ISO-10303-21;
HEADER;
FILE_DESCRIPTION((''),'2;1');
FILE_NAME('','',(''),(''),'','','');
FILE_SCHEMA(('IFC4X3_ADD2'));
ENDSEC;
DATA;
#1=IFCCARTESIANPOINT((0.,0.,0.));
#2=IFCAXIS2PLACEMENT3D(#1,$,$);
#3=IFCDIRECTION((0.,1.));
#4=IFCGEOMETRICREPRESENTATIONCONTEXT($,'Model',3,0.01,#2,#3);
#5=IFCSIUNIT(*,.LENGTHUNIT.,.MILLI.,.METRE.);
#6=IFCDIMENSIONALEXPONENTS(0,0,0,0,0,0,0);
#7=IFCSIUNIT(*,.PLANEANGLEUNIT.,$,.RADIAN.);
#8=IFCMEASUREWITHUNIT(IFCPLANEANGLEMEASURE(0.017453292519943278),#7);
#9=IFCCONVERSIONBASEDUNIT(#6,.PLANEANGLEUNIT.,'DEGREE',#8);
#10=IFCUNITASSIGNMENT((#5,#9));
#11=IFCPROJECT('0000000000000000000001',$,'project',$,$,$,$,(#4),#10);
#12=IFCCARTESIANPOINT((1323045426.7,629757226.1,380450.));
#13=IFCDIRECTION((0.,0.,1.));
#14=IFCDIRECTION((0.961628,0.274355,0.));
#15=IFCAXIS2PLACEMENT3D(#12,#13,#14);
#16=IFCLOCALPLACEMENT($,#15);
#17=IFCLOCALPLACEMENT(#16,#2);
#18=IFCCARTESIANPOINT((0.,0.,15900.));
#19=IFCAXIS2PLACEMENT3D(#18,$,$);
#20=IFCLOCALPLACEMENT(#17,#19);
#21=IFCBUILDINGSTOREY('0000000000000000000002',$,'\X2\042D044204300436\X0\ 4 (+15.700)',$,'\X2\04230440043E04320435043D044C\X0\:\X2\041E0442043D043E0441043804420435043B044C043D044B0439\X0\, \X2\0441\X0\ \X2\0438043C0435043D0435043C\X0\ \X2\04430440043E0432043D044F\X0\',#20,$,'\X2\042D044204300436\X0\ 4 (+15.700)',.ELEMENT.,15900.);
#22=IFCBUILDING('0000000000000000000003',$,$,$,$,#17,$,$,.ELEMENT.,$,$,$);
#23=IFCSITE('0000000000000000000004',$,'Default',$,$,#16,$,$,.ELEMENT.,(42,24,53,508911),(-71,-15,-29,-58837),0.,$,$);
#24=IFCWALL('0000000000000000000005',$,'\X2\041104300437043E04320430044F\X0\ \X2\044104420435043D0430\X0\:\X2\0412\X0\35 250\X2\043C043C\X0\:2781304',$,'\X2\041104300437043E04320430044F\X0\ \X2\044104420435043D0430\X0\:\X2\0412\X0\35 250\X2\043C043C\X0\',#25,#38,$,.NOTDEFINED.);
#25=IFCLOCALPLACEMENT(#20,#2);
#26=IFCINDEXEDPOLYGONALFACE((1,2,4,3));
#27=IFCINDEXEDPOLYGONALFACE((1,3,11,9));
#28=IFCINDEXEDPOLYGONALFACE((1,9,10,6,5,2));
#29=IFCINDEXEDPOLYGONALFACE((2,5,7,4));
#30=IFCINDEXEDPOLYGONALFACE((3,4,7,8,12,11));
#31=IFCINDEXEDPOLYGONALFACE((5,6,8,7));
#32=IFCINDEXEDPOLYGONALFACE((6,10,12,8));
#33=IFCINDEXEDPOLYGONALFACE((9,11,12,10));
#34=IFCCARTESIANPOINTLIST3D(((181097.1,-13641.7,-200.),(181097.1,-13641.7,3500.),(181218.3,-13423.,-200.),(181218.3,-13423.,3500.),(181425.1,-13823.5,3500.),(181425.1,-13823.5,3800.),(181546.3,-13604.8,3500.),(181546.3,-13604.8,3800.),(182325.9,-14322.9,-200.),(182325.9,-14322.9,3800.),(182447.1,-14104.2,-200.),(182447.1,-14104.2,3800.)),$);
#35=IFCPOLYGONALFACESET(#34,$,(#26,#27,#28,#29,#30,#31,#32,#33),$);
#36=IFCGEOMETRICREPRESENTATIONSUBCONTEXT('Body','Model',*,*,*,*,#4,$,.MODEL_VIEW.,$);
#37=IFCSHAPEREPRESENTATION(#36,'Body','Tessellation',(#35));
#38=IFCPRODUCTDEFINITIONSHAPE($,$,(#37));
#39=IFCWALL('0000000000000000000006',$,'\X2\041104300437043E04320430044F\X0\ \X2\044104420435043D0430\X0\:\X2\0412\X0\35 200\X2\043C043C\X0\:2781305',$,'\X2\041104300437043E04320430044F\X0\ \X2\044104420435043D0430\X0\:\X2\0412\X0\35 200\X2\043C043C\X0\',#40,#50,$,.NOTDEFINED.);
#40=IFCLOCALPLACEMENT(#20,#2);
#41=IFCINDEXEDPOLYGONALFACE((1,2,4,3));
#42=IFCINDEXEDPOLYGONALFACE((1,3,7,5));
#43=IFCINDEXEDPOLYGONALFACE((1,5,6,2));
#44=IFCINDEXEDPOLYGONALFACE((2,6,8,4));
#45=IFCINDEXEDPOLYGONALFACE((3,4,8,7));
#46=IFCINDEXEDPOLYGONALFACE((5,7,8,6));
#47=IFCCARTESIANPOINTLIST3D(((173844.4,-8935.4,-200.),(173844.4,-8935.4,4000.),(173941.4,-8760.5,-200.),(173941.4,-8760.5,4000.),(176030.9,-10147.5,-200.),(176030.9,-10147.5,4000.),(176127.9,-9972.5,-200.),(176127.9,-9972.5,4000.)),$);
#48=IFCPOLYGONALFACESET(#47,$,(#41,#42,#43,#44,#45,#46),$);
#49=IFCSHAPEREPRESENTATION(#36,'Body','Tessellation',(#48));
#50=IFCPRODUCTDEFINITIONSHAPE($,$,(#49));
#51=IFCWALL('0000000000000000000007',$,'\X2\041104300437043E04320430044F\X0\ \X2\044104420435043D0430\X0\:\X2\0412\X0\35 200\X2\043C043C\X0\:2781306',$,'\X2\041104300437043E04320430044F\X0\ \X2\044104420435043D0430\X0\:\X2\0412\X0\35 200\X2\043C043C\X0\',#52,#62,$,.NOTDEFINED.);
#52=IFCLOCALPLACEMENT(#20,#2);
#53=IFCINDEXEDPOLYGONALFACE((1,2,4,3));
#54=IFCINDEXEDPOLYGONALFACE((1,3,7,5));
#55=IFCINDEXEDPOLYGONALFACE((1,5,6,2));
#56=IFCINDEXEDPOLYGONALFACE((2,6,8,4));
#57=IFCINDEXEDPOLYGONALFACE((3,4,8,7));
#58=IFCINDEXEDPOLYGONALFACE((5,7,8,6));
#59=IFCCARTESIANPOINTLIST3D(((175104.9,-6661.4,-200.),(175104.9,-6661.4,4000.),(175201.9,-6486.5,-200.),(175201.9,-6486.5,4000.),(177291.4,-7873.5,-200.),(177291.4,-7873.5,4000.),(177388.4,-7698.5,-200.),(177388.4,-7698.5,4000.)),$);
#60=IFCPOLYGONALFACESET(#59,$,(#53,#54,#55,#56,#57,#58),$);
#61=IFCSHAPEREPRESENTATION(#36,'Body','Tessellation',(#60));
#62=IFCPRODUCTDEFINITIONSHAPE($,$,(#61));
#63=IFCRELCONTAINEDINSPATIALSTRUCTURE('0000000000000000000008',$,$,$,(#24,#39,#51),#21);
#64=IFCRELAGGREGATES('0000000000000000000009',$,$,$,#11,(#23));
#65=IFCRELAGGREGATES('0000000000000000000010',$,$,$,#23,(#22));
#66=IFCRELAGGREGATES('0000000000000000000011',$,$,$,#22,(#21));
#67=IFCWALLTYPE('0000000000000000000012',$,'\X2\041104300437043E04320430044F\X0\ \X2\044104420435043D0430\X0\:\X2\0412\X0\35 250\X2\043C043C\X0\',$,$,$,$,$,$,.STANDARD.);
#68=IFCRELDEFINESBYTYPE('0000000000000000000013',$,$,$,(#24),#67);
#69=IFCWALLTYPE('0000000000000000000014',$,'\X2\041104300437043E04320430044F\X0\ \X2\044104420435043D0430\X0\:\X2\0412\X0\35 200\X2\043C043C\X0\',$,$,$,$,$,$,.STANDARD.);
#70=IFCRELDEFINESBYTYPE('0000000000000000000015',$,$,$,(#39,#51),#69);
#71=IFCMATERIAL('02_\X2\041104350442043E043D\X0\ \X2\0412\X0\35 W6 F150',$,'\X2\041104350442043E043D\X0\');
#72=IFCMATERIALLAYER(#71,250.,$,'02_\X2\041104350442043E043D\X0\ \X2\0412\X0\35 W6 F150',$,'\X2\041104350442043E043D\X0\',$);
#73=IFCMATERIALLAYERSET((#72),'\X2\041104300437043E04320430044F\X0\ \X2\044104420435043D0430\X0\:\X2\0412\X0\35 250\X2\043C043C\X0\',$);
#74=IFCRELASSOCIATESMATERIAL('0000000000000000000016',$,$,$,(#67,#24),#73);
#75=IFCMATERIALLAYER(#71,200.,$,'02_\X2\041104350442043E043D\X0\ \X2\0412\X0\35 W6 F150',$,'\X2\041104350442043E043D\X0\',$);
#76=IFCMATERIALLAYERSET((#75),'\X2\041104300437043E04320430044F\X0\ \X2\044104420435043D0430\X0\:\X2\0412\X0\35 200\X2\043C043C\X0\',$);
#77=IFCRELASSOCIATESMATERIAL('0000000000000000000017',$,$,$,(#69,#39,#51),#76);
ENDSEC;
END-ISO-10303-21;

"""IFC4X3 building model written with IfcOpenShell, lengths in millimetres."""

from ifc_helpers import new_model, entity, si_unit, converted_unit, direction, frame, frame_2d, origin, place, context, subcontext, project, spatial, polyline, rectangle, extrude, clip, bounded_halfspace, material, layer, layer_set, type_object, element, save


model = new_model("IFC4X3")

# Units and contexts
model_context = context("Model", 3, precision=0.01, world=origin(), true_north=direction((0.0, 1.0)))
body_context = subcontext(model_context, "Body", "Model", "MODEL_VIEW")
ifc_project = project(units=[si_unit("LENGTHUNIT", "METRE", prefix="MILLI"), converted_unit("PLANEANGLEUNIT", "DEGREE", entity("IfcPlaneAngleMeasure", 0.017453292519943278), si_unit("PLANEANGLEUNIT", "RADIAN"), dimensions=[0, 0, 0, 0, 0, 0, 0])], contexts=[model_context])

# Site, building, storey
site_placement = place(None, frame((1323045426.7, 629757226.1, 380450.0), z_axis=(0.0, 0.0, 1.0), x_axis=(0.961628, 0.274355, 0.0)))
site = spatial("IfcSite", under=ifc_project, at=site_placement, Name="Default", CompositionType="ELEMENT", RefLatitude=(42, 24, 53, 508911), RefLongitude=(-71, -15, -29, -58837), RefElevation=0.0)
building_placement = place(site_placement, origin())
building = spatial("IfcBuilding", under=site, at=building_placement, CompositionType="ELEMENT")
storey_placement = place(building_placement, frame((0.0, 0.0, 15900.0)))
storey = spatial("IfcBuildingStorey", under=building, at=storey_placement, Name="Этаж 4 (+15.700)", ObjectType="Уровень:Относительный, с именем уровня", LongName="Этаж 4 (+15.700)", CompositionType="ELEMENT", Elevation=15900.0)

# Shared definitions
ifc_material = material(Name="02_Бетон В35 W6 F150", Category="Бетон")
ifc_layer_1 = layer(ifc_material, 250.0, Name="02_Бетон В35 W6 F150", Category="Бетон")
ifc_layer_set_1 = layer_set([ifc_layer_1], Name="Базовая стена:В35 250мм")
wall_type_1 = type_object("IfcWallType", Name="Базовая стена:В35 250мм", PredefinedType="STANDARD", material=ifc_layer_set_1)

# Wall, opening
wall_1_placement = place(storey_placement, frame((181157.7, -13532.4, -200.0), z_axis=(0.0, 0.0, 1.0), x_axis=(0.87462, -0.48481, 0.0)))
wall_1 = element("IfcWall", 1, at=wall_1_placement, inside=storey, type_object=wall_type_1, material=ifc_layer_set_1, Name="Базовая стена:В35 250мм:2781304", ObjectType="Базовая стена:В35 250мм", PredefinedType="NOTDEFINED", context=body_context, shape_type="Clipping", body=[
    clip(clip(extrude(rectangle(XDim=1405.0, YDim=250.0, at=frame_2d((702.5, 0.0), x_axis=(-1.0, 0.0))), origin(), (0.0, 0.0, 1.0), 4000.0), bounded_halfspace(frame((375.0, -125.0, 4000.0), z_axis=(0.0, 0.0, -1.0), x_axis=(0.48481, -0.87462, 0.0)), True, frame((375.0, -125.0, 4000.0)), polyline([(0.0, 0.0), (1030.0, 0.0), (1030.0, 250.0), (0.0, 250.0), (0.0, 0.0)]))), bounded_halfspace(frame((0.0, -125.0, 0.0), z_axis=(1.0, 0.0, 0.0), x_axis=(0.0, 1.0, 0.0)), True, frame((0.0, -125.0, 0.0), z_axis=(1.0, 0.0, 0.0), x_axis=(0.0, 1.0, 0.0)), polyline([(0.0, 0.0), (250.0, 0.0), (250.0, 3700.0), (125.0, 3700.0), (0.0, 3700.0), (0.0, 0.0)]))),
])
opening_1_placement = place(wall_1_placement, origin())
element("IfcOpeningElement", 2, at=opening_1_placement, cuts=wall_1, PredefinedType="OPENING", context=body_context, shape_type="SweptSolid", body=[
    extrude(rectangle(XDim=300.0, YDim=500.0, at=frame_2d((0.0, 0.0), x_axis=(0.0, 1.0))), frame((125.0, 125.0, 3850.0), z_axis=(0.0, -1.0, 0.0), x_axis=(-1.0, 0.0, 0.0)), (0.0, 0.0, 1.0), 250.0),
])

# Walls
ifc_layer_2 = layer(ifc_material, 200.0, Name="02_Бетон В35 W6 F150", Category="Бетон")
ifc_layer_set_2 = layer_set([ifc_layer_2], Name="Базовая стена:В35 200мм")
wall_type_2 = type_object("IfcWallType", Name="Базовая стена:В35 200мм", PredefinedType="STANDARD", material=ifc_layer_set_2)
wall_2_placement = place(storey_placement, frame((173892.9, -8848.0, -200.0), z_axis=(0.0, 0.0, 1.0), x_axis=(0.87462, -0.48481, 0.0)))
element("IfcWall", 3, at=wall_2_placement, inside=storey, type_object=wall_type_2, material=ifc_layer_set_2, Name="Базовая стена:В35 200мм:2781305", ObjectType="Базовая стена:В35 200мм", PredefinedType="NOTDEFINED", context=body_context, shape_type="SweptSolid", body=[
    extrude(rectangle(XDim=2500.0, YDim=200.0, at=frame_2d((1250.0, 0.0), x_axis=(-1.0, 0.0))), origin(), (0.0, 0.0, 1.0), 4200.0),
])
wall_3_placement = place(storey_placement, frame((175153.4, -6574.0, -200.0), z_axis=(0.0, 0.0, 1.0), x_axis=(0.87462, -0.48481, 0.0)))
element("IfcWall", 4, at=wall_3_placement, inside=storey, type_object=wall_type_2, material=ifc_layer_set_2, Name="Базовая стена:В35 200мм:2781306", ObjectType="Базовая стена:В35 200мм", PredefinedType="NOTDEFINED", context=body_context, shape_type="SweptSolid", body=[
    extrude(rectangle(XDim=2500.0, YDim=200.0, at=frame_2d((1250.0, 0.0), x_axis=(-1.0, 0.0))), origin(), (0.0, 0.0, 1.0), 4200.0),
])

save(model, "model.ifc")
